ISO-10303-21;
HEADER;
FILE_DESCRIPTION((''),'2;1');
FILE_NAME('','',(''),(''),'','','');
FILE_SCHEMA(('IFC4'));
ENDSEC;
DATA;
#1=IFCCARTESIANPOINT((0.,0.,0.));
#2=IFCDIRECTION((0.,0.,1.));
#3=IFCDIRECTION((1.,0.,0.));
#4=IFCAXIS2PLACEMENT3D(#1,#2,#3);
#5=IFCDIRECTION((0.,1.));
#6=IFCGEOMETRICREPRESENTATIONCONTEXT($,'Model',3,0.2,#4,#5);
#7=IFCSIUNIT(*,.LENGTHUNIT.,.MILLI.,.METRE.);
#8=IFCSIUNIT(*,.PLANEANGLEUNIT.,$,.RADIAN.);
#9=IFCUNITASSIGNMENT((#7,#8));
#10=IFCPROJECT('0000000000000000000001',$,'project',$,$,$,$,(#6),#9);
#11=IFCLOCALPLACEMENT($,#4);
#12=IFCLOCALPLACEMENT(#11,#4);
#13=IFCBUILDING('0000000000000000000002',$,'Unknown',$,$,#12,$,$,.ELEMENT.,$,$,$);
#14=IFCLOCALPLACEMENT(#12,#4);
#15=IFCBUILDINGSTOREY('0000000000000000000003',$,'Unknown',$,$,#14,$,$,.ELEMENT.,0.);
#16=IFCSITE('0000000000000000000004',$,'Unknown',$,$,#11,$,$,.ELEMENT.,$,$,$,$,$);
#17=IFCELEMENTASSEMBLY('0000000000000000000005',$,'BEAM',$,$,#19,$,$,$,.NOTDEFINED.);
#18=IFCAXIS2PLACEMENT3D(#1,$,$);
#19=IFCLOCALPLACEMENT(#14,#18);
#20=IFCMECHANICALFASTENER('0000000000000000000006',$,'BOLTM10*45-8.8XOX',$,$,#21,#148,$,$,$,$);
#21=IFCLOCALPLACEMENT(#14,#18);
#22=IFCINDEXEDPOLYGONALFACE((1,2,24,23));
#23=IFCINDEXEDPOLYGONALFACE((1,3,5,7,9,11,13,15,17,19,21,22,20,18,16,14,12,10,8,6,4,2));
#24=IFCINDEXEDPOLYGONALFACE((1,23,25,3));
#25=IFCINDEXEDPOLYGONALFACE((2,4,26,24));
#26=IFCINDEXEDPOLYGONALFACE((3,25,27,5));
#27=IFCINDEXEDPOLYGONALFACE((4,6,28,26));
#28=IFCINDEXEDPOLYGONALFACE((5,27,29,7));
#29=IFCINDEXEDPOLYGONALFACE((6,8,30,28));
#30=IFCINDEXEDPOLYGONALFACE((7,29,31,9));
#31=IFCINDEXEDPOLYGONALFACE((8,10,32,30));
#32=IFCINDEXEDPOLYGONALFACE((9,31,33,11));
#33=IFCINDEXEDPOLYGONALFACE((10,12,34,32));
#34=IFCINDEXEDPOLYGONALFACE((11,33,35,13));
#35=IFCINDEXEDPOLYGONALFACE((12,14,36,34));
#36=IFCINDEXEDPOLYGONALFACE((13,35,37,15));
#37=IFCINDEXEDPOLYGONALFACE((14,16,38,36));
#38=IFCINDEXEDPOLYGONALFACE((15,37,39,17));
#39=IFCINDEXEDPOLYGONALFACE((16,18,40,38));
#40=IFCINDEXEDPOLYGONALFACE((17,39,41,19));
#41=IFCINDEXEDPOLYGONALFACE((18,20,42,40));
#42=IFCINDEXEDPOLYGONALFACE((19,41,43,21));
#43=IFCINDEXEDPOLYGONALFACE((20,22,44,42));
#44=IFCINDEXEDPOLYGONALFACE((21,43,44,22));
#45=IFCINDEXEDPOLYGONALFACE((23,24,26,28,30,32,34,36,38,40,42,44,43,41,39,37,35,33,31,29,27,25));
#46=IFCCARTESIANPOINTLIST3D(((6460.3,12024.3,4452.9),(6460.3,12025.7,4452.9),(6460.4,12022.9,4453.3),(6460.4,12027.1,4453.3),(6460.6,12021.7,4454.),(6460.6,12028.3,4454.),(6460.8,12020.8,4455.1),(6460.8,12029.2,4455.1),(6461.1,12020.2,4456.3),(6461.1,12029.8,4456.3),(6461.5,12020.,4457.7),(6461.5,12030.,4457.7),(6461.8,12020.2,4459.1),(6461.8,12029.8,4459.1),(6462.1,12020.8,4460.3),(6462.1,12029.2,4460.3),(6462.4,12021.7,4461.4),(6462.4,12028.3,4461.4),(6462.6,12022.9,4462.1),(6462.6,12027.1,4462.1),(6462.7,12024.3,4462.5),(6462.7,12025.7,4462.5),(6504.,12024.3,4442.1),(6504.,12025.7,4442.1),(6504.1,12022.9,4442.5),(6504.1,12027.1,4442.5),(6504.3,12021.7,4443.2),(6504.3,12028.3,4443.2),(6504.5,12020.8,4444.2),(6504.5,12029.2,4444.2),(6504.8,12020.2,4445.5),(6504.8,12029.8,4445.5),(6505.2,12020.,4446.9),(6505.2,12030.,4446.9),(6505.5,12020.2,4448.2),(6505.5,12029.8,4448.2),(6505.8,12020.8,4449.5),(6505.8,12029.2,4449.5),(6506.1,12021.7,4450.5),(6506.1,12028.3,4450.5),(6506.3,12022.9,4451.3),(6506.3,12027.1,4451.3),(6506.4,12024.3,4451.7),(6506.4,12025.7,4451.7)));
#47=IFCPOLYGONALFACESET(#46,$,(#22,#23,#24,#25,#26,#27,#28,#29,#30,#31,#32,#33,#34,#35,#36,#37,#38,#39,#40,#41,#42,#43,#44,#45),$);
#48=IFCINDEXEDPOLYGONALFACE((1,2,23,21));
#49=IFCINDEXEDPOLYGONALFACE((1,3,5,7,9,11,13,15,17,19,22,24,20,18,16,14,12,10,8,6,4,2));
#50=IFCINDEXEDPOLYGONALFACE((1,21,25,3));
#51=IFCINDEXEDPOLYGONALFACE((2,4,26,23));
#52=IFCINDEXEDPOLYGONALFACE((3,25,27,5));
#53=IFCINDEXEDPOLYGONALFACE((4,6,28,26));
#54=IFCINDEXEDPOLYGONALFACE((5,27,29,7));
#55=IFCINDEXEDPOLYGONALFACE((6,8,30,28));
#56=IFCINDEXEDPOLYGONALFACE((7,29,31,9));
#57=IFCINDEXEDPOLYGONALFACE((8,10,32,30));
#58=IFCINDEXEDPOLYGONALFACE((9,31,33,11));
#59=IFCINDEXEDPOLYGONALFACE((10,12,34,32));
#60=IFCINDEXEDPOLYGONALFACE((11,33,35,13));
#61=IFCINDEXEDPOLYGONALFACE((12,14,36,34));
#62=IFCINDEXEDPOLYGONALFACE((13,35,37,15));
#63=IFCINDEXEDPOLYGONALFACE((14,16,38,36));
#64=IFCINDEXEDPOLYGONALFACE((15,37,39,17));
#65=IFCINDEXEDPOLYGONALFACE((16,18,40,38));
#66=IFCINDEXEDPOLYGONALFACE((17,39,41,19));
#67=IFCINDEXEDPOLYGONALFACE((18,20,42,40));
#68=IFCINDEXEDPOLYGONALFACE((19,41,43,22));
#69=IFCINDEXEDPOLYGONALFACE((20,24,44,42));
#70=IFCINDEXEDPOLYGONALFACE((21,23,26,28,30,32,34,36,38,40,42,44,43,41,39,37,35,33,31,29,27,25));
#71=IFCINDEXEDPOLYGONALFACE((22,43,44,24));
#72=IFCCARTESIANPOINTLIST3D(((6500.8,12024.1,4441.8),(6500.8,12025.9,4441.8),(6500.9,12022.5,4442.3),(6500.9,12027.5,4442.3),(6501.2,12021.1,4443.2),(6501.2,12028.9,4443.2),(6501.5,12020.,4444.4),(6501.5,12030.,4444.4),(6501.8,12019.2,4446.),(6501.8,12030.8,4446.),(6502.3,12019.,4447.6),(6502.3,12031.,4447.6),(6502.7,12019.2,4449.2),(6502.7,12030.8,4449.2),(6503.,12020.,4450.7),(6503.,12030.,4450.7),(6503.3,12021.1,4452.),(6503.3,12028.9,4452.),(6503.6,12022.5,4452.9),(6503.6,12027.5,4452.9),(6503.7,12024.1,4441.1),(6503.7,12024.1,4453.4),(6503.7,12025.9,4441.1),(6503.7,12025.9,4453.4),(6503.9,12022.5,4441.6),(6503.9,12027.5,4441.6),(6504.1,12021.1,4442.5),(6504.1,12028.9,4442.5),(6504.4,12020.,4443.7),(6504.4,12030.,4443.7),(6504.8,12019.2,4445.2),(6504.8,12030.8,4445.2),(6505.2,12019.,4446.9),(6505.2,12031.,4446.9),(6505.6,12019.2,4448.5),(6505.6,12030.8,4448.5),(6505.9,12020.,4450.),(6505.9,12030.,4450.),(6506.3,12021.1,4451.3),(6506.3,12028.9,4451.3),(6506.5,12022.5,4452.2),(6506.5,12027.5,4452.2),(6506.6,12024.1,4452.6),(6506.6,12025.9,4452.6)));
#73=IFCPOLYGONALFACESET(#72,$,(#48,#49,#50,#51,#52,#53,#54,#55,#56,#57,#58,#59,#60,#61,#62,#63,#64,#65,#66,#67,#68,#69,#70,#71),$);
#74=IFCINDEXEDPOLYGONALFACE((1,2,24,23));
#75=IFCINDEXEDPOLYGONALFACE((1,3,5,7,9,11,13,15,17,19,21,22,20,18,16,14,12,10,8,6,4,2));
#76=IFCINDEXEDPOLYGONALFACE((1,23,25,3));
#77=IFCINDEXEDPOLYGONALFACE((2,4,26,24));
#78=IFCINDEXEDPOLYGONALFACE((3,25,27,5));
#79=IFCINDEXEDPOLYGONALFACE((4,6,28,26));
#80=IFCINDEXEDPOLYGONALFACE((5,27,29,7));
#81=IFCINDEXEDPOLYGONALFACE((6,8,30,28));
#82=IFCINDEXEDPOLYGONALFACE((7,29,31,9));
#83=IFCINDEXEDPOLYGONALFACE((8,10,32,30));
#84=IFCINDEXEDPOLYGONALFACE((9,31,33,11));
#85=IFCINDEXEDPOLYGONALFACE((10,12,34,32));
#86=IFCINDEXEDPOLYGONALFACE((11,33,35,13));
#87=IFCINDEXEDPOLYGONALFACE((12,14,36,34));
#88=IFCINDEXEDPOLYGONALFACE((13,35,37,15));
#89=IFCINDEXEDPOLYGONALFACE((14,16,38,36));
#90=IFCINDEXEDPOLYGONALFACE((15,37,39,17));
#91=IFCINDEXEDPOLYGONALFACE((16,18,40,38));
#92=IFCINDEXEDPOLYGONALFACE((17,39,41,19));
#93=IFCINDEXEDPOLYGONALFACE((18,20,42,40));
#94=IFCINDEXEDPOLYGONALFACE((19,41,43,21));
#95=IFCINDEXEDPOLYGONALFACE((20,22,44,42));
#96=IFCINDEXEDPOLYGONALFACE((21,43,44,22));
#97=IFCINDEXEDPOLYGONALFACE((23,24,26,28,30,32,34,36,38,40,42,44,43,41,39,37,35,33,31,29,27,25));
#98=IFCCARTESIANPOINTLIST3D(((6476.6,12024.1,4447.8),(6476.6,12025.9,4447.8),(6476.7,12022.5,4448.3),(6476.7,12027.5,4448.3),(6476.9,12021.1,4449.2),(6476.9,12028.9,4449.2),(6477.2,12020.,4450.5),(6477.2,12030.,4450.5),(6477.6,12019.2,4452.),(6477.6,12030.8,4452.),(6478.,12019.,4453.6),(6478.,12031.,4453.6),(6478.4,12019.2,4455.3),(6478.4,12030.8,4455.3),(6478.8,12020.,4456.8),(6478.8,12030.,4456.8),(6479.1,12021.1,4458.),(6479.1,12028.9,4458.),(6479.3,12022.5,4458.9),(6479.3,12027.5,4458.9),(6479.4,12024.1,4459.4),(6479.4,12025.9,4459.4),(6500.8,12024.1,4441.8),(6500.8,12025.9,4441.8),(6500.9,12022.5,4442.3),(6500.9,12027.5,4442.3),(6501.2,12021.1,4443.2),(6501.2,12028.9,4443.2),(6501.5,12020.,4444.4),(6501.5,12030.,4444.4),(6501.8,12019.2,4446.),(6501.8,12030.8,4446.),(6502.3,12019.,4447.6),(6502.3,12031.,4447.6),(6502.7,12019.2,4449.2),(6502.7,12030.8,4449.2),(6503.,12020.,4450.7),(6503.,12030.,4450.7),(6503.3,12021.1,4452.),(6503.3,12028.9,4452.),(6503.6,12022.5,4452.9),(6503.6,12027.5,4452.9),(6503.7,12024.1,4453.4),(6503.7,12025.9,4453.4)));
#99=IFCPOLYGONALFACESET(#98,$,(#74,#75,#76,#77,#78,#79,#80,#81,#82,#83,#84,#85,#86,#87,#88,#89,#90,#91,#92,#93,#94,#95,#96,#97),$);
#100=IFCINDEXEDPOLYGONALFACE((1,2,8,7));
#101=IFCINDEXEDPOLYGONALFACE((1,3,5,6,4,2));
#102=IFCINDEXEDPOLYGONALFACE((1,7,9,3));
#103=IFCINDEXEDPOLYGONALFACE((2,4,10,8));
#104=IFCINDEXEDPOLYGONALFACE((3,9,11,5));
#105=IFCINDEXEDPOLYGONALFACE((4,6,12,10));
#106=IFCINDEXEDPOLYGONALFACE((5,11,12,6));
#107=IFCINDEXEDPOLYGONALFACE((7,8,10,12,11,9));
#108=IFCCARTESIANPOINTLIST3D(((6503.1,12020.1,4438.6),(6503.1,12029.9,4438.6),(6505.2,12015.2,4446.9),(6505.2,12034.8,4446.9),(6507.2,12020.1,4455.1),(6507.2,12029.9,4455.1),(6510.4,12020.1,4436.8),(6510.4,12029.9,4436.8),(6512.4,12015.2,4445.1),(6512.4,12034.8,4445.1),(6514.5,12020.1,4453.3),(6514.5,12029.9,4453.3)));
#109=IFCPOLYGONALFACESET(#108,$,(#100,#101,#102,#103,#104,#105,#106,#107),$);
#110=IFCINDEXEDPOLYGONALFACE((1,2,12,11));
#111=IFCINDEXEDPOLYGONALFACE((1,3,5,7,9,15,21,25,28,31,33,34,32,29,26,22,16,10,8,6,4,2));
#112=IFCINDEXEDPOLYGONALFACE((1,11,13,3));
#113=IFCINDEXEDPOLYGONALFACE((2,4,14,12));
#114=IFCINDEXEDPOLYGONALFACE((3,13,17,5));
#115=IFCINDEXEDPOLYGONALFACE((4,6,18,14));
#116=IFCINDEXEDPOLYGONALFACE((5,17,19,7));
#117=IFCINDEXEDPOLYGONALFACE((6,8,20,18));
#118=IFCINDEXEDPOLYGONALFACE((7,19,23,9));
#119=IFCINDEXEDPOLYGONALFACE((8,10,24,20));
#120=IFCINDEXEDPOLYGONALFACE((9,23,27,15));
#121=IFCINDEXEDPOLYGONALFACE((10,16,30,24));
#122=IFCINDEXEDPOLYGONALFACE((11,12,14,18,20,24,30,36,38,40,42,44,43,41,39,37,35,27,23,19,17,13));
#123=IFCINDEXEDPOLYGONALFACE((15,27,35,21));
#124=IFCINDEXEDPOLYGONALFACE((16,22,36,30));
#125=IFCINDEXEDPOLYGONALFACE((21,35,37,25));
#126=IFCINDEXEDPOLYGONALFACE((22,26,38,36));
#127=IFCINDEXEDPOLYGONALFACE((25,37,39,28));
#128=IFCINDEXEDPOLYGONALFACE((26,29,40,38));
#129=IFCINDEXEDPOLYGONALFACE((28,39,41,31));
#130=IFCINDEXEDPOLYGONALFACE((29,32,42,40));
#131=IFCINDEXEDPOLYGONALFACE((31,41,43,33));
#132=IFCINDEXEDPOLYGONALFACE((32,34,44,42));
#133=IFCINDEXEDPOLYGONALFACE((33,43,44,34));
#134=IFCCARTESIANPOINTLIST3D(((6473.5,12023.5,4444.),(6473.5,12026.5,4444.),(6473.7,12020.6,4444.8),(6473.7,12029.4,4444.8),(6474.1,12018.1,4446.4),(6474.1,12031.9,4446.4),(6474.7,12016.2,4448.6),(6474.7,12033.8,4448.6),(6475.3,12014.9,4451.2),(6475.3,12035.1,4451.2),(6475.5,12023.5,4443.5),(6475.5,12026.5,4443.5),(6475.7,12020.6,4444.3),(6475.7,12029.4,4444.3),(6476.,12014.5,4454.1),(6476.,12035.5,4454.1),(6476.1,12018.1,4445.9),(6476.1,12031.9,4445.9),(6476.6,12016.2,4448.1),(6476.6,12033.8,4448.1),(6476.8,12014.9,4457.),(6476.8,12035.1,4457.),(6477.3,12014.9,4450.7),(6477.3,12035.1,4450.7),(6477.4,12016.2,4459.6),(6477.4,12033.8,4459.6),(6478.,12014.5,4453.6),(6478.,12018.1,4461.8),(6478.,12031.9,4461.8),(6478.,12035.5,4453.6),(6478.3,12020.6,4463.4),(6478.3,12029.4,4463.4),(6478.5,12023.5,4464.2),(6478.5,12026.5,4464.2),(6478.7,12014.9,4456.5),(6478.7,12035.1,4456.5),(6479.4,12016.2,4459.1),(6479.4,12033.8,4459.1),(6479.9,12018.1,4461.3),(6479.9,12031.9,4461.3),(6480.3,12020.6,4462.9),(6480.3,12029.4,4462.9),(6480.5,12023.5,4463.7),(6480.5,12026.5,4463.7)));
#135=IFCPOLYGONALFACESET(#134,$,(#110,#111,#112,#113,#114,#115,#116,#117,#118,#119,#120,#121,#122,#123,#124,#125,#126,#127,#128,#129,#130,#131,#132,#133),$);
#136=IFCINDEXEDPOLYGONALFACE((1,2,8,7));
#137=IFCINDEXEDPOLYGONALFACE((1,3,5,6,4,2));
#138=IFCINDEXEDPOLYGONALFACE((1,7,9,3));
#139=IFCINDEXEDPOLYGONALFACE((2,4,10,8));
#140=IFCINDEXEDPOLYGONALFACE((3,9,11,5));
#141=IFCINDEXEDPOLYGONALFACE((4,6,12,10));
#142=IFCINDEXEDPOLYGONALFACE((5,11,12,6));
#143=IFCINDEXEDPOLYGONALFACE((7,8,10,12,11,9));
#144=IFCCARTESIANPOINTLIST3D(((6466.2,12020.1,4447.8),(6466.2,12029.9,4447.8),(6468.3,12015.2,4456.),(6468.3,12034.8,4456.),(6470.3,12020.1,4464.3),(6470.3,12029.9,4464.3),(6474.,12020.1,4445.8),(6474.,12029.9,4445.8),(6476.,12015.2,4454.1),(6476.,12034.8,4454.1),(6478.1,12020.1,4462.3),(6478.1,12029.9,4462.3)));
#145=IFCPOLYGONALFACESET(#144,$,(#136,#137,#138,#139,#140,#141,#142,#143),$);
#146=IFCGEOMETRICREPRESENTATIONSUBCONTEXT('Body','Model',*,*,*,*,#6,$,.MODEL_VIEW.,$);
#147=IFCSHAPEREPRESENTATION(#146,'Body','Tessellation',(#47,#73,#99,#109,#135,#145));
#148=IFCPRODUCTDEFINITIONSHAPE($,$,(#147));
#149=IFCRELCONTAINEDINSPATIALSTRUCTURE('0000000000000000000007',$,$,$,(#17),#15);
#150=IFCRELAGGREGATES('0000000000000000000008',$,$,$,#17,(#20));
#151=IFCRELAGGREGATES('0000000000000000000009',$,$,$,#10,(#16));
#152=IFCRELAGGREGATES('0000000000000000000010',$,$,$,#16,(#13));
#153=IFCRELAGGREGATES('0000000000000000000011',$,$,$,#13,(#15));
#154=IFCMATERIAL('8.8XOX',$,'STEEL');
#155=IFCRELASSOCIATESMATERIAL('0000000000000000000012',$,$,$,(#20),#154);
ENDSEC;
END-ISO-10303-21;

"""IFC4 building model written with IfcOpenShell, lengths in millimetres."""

from ifc_helpers import new_model, si_unit, direction, frame, origin_with_axes, place, context, subcontext, project, spatial, line, arc, indexed_curve, outline, extrude, source, transform, mapped, material, element, aggregate, save


model = new_model("IFC4")

# Units and contexts
model_context = context("Model", 3, precision=0.2, world=origin_with_axes(), true_north=direction((0.0, 1.0)))
body_context = subcontext(model_context, "Body", "Model", "MODEL_VIEW")
ifc_project = project(units=[si_unit("LENGTHUNIT", "METRE", prefix="MILLI"), si_unit("PLANEANGLEUNIT", "RADIAN")], contexts=[model_context])

# Site, building, storey
site_placement = place(None, origin_with_axes())
site = spatial("IfcSite", under=ifc_project, at=site_placement, Name="Unknown", CompositionType="ELEMENT")
building_placement = place(site_placement, origin_with_axes())
building = spatial("IfcBuilding", under=site, at=building_placement, Name="Unknown", CompositionType="ELEMENT")
storey_placement = place(building_placement, origin_with_axes())
storey = spatial("IfcBuildingStorey", under=building, at=storey_placement, Name="Unknown", CompositionType="ELEMENT", Elevation=0.0)

# Shared definitions
ifc_material_1 = material(Name="8.8XOX", Category="STEEL")

# Element assembly, mechanical fastener
shared_shape_1 = source(origin_with_axes(), body_context, "Body", "SweptSolid", [
    extrude(outline(indexed_curve([(5.0, 0.0), (0.0, 5.0), (-5.0, 0.0), (0.0, -5.0)], segments=[arc(1, 2, 3), arc(3, 4, 1)])), frame((0.0, 0.0, 3.8), z_axis=(0.0, 0.0, -1.0), x_axis=(0.0, 1.0, 0.0)), (0.0, 0.0, 1.0), 45.0),
    extrude(outline(indexed_curve([(6.0, 0.0), (0.0, 6.0), (-6.0, 0.0), (0.0, -6.0)], segments=[arc(1, 2, 3), arc(3, 4, 1)])), frame((0.0, 0.0, 3.8), z_axis=(0.0, 0.0, -1.0), x_axis=(0.0, 1.0, 0.0)), (0.0, 0.0, 1.0), 3.0),
    extrude(outline(indexed_curve([(6.0, 0.0), (0.0, 6.0), (-6.0, 0.0), (0.0, -6.0)], segments=[arc(1, 2, 3), arc(3, 4, 1)])), frame((0.0, 0.0, 0.8), z_axis=(0.0, 0.0, -1.0), x_axis=(0.0, 1.0, 0.0)), (0.0, 0.0, 1.0), 25.0),
    extrude(outline(indexed_curve([(9.8, 0.0), (4.9, 8.5), (-4.9, 8.5), (-9.8, 0.0), (-4.9, -8.5), (4.9, -8.5)], segments=[line(1, 2, 3, 4, 5, 6, 1)])), frame((0.0, 0.0, 11.2), z_axis=(0.0, 0.0, -1.0), x_axis=(0.0, 1.0, 0.0)), (0.0, 0.0, 1.0), 7.5),
    extrude(outline(indexed_curve([(10.5, 0.0), (0.0, 10.5), (-10.5, 0.0), (0.0, -10.5)], segments=[arc(1, 2, 3), arc(3, 4, 1)])), frame((0.0, 0.0, -24.2), z_axis=(0.0, 0.0, -1.0), x_axis=(0.0, 1.0, 0.0)), (0.0, 0.0, 1.0), 2.0),
    extrude(outline(indexed_curve([(9.8, 0.0), (4.9, 8.5), (-4.9, 8.5), (-9.8, 0.0), (-4.9, -8.5), (4.9, -8.5)], segments=[line(1, 2, 3, 4, 5, 6, 1)])), frame((0.0, 0.0, -26.2), z_axis=(0.0, 0.0, -1.0), x_axis=(0.0, 1.0, 0.0)), (0.0, 0.0, 1.0), 8.0),
])
assembly_1_placement = place(storey_placement, frame((6491.3, 12000.0, 4455.5), z_axis=(0.970613, 0.0, -0.240648), x_axis=(0.0, 1.0, 0.0)))
assembly_1 = element("IfcElementAssembly", 1, at=assembly_1_placement, inside=storey, Name="BEAM", PredefinedType="NOTDEFINED")
mechanical_fastener_1_placement = place(assembly_1_placement, frame((25.0, -5.0, 11.8), z_axis=(0.0, 0.0, 1.0), x_axis=(0.0, 1.0, 0.0)))
mechanical_fastener_1 = element("IfcMechanicalFastener", 2, at=mechanical_fastener_1_placement, material=ifc_material_1, Name="BOLTM10*45-8.8XOX", context=body_context, shape_type="MappedRepresentation", body=[
    mapped(shared_shape_1, transform((0.0, 0.0, 0.0))),
])
aggregate(assembly_1, [mechanical_fastener_1])

save(model, "model.ifc")
